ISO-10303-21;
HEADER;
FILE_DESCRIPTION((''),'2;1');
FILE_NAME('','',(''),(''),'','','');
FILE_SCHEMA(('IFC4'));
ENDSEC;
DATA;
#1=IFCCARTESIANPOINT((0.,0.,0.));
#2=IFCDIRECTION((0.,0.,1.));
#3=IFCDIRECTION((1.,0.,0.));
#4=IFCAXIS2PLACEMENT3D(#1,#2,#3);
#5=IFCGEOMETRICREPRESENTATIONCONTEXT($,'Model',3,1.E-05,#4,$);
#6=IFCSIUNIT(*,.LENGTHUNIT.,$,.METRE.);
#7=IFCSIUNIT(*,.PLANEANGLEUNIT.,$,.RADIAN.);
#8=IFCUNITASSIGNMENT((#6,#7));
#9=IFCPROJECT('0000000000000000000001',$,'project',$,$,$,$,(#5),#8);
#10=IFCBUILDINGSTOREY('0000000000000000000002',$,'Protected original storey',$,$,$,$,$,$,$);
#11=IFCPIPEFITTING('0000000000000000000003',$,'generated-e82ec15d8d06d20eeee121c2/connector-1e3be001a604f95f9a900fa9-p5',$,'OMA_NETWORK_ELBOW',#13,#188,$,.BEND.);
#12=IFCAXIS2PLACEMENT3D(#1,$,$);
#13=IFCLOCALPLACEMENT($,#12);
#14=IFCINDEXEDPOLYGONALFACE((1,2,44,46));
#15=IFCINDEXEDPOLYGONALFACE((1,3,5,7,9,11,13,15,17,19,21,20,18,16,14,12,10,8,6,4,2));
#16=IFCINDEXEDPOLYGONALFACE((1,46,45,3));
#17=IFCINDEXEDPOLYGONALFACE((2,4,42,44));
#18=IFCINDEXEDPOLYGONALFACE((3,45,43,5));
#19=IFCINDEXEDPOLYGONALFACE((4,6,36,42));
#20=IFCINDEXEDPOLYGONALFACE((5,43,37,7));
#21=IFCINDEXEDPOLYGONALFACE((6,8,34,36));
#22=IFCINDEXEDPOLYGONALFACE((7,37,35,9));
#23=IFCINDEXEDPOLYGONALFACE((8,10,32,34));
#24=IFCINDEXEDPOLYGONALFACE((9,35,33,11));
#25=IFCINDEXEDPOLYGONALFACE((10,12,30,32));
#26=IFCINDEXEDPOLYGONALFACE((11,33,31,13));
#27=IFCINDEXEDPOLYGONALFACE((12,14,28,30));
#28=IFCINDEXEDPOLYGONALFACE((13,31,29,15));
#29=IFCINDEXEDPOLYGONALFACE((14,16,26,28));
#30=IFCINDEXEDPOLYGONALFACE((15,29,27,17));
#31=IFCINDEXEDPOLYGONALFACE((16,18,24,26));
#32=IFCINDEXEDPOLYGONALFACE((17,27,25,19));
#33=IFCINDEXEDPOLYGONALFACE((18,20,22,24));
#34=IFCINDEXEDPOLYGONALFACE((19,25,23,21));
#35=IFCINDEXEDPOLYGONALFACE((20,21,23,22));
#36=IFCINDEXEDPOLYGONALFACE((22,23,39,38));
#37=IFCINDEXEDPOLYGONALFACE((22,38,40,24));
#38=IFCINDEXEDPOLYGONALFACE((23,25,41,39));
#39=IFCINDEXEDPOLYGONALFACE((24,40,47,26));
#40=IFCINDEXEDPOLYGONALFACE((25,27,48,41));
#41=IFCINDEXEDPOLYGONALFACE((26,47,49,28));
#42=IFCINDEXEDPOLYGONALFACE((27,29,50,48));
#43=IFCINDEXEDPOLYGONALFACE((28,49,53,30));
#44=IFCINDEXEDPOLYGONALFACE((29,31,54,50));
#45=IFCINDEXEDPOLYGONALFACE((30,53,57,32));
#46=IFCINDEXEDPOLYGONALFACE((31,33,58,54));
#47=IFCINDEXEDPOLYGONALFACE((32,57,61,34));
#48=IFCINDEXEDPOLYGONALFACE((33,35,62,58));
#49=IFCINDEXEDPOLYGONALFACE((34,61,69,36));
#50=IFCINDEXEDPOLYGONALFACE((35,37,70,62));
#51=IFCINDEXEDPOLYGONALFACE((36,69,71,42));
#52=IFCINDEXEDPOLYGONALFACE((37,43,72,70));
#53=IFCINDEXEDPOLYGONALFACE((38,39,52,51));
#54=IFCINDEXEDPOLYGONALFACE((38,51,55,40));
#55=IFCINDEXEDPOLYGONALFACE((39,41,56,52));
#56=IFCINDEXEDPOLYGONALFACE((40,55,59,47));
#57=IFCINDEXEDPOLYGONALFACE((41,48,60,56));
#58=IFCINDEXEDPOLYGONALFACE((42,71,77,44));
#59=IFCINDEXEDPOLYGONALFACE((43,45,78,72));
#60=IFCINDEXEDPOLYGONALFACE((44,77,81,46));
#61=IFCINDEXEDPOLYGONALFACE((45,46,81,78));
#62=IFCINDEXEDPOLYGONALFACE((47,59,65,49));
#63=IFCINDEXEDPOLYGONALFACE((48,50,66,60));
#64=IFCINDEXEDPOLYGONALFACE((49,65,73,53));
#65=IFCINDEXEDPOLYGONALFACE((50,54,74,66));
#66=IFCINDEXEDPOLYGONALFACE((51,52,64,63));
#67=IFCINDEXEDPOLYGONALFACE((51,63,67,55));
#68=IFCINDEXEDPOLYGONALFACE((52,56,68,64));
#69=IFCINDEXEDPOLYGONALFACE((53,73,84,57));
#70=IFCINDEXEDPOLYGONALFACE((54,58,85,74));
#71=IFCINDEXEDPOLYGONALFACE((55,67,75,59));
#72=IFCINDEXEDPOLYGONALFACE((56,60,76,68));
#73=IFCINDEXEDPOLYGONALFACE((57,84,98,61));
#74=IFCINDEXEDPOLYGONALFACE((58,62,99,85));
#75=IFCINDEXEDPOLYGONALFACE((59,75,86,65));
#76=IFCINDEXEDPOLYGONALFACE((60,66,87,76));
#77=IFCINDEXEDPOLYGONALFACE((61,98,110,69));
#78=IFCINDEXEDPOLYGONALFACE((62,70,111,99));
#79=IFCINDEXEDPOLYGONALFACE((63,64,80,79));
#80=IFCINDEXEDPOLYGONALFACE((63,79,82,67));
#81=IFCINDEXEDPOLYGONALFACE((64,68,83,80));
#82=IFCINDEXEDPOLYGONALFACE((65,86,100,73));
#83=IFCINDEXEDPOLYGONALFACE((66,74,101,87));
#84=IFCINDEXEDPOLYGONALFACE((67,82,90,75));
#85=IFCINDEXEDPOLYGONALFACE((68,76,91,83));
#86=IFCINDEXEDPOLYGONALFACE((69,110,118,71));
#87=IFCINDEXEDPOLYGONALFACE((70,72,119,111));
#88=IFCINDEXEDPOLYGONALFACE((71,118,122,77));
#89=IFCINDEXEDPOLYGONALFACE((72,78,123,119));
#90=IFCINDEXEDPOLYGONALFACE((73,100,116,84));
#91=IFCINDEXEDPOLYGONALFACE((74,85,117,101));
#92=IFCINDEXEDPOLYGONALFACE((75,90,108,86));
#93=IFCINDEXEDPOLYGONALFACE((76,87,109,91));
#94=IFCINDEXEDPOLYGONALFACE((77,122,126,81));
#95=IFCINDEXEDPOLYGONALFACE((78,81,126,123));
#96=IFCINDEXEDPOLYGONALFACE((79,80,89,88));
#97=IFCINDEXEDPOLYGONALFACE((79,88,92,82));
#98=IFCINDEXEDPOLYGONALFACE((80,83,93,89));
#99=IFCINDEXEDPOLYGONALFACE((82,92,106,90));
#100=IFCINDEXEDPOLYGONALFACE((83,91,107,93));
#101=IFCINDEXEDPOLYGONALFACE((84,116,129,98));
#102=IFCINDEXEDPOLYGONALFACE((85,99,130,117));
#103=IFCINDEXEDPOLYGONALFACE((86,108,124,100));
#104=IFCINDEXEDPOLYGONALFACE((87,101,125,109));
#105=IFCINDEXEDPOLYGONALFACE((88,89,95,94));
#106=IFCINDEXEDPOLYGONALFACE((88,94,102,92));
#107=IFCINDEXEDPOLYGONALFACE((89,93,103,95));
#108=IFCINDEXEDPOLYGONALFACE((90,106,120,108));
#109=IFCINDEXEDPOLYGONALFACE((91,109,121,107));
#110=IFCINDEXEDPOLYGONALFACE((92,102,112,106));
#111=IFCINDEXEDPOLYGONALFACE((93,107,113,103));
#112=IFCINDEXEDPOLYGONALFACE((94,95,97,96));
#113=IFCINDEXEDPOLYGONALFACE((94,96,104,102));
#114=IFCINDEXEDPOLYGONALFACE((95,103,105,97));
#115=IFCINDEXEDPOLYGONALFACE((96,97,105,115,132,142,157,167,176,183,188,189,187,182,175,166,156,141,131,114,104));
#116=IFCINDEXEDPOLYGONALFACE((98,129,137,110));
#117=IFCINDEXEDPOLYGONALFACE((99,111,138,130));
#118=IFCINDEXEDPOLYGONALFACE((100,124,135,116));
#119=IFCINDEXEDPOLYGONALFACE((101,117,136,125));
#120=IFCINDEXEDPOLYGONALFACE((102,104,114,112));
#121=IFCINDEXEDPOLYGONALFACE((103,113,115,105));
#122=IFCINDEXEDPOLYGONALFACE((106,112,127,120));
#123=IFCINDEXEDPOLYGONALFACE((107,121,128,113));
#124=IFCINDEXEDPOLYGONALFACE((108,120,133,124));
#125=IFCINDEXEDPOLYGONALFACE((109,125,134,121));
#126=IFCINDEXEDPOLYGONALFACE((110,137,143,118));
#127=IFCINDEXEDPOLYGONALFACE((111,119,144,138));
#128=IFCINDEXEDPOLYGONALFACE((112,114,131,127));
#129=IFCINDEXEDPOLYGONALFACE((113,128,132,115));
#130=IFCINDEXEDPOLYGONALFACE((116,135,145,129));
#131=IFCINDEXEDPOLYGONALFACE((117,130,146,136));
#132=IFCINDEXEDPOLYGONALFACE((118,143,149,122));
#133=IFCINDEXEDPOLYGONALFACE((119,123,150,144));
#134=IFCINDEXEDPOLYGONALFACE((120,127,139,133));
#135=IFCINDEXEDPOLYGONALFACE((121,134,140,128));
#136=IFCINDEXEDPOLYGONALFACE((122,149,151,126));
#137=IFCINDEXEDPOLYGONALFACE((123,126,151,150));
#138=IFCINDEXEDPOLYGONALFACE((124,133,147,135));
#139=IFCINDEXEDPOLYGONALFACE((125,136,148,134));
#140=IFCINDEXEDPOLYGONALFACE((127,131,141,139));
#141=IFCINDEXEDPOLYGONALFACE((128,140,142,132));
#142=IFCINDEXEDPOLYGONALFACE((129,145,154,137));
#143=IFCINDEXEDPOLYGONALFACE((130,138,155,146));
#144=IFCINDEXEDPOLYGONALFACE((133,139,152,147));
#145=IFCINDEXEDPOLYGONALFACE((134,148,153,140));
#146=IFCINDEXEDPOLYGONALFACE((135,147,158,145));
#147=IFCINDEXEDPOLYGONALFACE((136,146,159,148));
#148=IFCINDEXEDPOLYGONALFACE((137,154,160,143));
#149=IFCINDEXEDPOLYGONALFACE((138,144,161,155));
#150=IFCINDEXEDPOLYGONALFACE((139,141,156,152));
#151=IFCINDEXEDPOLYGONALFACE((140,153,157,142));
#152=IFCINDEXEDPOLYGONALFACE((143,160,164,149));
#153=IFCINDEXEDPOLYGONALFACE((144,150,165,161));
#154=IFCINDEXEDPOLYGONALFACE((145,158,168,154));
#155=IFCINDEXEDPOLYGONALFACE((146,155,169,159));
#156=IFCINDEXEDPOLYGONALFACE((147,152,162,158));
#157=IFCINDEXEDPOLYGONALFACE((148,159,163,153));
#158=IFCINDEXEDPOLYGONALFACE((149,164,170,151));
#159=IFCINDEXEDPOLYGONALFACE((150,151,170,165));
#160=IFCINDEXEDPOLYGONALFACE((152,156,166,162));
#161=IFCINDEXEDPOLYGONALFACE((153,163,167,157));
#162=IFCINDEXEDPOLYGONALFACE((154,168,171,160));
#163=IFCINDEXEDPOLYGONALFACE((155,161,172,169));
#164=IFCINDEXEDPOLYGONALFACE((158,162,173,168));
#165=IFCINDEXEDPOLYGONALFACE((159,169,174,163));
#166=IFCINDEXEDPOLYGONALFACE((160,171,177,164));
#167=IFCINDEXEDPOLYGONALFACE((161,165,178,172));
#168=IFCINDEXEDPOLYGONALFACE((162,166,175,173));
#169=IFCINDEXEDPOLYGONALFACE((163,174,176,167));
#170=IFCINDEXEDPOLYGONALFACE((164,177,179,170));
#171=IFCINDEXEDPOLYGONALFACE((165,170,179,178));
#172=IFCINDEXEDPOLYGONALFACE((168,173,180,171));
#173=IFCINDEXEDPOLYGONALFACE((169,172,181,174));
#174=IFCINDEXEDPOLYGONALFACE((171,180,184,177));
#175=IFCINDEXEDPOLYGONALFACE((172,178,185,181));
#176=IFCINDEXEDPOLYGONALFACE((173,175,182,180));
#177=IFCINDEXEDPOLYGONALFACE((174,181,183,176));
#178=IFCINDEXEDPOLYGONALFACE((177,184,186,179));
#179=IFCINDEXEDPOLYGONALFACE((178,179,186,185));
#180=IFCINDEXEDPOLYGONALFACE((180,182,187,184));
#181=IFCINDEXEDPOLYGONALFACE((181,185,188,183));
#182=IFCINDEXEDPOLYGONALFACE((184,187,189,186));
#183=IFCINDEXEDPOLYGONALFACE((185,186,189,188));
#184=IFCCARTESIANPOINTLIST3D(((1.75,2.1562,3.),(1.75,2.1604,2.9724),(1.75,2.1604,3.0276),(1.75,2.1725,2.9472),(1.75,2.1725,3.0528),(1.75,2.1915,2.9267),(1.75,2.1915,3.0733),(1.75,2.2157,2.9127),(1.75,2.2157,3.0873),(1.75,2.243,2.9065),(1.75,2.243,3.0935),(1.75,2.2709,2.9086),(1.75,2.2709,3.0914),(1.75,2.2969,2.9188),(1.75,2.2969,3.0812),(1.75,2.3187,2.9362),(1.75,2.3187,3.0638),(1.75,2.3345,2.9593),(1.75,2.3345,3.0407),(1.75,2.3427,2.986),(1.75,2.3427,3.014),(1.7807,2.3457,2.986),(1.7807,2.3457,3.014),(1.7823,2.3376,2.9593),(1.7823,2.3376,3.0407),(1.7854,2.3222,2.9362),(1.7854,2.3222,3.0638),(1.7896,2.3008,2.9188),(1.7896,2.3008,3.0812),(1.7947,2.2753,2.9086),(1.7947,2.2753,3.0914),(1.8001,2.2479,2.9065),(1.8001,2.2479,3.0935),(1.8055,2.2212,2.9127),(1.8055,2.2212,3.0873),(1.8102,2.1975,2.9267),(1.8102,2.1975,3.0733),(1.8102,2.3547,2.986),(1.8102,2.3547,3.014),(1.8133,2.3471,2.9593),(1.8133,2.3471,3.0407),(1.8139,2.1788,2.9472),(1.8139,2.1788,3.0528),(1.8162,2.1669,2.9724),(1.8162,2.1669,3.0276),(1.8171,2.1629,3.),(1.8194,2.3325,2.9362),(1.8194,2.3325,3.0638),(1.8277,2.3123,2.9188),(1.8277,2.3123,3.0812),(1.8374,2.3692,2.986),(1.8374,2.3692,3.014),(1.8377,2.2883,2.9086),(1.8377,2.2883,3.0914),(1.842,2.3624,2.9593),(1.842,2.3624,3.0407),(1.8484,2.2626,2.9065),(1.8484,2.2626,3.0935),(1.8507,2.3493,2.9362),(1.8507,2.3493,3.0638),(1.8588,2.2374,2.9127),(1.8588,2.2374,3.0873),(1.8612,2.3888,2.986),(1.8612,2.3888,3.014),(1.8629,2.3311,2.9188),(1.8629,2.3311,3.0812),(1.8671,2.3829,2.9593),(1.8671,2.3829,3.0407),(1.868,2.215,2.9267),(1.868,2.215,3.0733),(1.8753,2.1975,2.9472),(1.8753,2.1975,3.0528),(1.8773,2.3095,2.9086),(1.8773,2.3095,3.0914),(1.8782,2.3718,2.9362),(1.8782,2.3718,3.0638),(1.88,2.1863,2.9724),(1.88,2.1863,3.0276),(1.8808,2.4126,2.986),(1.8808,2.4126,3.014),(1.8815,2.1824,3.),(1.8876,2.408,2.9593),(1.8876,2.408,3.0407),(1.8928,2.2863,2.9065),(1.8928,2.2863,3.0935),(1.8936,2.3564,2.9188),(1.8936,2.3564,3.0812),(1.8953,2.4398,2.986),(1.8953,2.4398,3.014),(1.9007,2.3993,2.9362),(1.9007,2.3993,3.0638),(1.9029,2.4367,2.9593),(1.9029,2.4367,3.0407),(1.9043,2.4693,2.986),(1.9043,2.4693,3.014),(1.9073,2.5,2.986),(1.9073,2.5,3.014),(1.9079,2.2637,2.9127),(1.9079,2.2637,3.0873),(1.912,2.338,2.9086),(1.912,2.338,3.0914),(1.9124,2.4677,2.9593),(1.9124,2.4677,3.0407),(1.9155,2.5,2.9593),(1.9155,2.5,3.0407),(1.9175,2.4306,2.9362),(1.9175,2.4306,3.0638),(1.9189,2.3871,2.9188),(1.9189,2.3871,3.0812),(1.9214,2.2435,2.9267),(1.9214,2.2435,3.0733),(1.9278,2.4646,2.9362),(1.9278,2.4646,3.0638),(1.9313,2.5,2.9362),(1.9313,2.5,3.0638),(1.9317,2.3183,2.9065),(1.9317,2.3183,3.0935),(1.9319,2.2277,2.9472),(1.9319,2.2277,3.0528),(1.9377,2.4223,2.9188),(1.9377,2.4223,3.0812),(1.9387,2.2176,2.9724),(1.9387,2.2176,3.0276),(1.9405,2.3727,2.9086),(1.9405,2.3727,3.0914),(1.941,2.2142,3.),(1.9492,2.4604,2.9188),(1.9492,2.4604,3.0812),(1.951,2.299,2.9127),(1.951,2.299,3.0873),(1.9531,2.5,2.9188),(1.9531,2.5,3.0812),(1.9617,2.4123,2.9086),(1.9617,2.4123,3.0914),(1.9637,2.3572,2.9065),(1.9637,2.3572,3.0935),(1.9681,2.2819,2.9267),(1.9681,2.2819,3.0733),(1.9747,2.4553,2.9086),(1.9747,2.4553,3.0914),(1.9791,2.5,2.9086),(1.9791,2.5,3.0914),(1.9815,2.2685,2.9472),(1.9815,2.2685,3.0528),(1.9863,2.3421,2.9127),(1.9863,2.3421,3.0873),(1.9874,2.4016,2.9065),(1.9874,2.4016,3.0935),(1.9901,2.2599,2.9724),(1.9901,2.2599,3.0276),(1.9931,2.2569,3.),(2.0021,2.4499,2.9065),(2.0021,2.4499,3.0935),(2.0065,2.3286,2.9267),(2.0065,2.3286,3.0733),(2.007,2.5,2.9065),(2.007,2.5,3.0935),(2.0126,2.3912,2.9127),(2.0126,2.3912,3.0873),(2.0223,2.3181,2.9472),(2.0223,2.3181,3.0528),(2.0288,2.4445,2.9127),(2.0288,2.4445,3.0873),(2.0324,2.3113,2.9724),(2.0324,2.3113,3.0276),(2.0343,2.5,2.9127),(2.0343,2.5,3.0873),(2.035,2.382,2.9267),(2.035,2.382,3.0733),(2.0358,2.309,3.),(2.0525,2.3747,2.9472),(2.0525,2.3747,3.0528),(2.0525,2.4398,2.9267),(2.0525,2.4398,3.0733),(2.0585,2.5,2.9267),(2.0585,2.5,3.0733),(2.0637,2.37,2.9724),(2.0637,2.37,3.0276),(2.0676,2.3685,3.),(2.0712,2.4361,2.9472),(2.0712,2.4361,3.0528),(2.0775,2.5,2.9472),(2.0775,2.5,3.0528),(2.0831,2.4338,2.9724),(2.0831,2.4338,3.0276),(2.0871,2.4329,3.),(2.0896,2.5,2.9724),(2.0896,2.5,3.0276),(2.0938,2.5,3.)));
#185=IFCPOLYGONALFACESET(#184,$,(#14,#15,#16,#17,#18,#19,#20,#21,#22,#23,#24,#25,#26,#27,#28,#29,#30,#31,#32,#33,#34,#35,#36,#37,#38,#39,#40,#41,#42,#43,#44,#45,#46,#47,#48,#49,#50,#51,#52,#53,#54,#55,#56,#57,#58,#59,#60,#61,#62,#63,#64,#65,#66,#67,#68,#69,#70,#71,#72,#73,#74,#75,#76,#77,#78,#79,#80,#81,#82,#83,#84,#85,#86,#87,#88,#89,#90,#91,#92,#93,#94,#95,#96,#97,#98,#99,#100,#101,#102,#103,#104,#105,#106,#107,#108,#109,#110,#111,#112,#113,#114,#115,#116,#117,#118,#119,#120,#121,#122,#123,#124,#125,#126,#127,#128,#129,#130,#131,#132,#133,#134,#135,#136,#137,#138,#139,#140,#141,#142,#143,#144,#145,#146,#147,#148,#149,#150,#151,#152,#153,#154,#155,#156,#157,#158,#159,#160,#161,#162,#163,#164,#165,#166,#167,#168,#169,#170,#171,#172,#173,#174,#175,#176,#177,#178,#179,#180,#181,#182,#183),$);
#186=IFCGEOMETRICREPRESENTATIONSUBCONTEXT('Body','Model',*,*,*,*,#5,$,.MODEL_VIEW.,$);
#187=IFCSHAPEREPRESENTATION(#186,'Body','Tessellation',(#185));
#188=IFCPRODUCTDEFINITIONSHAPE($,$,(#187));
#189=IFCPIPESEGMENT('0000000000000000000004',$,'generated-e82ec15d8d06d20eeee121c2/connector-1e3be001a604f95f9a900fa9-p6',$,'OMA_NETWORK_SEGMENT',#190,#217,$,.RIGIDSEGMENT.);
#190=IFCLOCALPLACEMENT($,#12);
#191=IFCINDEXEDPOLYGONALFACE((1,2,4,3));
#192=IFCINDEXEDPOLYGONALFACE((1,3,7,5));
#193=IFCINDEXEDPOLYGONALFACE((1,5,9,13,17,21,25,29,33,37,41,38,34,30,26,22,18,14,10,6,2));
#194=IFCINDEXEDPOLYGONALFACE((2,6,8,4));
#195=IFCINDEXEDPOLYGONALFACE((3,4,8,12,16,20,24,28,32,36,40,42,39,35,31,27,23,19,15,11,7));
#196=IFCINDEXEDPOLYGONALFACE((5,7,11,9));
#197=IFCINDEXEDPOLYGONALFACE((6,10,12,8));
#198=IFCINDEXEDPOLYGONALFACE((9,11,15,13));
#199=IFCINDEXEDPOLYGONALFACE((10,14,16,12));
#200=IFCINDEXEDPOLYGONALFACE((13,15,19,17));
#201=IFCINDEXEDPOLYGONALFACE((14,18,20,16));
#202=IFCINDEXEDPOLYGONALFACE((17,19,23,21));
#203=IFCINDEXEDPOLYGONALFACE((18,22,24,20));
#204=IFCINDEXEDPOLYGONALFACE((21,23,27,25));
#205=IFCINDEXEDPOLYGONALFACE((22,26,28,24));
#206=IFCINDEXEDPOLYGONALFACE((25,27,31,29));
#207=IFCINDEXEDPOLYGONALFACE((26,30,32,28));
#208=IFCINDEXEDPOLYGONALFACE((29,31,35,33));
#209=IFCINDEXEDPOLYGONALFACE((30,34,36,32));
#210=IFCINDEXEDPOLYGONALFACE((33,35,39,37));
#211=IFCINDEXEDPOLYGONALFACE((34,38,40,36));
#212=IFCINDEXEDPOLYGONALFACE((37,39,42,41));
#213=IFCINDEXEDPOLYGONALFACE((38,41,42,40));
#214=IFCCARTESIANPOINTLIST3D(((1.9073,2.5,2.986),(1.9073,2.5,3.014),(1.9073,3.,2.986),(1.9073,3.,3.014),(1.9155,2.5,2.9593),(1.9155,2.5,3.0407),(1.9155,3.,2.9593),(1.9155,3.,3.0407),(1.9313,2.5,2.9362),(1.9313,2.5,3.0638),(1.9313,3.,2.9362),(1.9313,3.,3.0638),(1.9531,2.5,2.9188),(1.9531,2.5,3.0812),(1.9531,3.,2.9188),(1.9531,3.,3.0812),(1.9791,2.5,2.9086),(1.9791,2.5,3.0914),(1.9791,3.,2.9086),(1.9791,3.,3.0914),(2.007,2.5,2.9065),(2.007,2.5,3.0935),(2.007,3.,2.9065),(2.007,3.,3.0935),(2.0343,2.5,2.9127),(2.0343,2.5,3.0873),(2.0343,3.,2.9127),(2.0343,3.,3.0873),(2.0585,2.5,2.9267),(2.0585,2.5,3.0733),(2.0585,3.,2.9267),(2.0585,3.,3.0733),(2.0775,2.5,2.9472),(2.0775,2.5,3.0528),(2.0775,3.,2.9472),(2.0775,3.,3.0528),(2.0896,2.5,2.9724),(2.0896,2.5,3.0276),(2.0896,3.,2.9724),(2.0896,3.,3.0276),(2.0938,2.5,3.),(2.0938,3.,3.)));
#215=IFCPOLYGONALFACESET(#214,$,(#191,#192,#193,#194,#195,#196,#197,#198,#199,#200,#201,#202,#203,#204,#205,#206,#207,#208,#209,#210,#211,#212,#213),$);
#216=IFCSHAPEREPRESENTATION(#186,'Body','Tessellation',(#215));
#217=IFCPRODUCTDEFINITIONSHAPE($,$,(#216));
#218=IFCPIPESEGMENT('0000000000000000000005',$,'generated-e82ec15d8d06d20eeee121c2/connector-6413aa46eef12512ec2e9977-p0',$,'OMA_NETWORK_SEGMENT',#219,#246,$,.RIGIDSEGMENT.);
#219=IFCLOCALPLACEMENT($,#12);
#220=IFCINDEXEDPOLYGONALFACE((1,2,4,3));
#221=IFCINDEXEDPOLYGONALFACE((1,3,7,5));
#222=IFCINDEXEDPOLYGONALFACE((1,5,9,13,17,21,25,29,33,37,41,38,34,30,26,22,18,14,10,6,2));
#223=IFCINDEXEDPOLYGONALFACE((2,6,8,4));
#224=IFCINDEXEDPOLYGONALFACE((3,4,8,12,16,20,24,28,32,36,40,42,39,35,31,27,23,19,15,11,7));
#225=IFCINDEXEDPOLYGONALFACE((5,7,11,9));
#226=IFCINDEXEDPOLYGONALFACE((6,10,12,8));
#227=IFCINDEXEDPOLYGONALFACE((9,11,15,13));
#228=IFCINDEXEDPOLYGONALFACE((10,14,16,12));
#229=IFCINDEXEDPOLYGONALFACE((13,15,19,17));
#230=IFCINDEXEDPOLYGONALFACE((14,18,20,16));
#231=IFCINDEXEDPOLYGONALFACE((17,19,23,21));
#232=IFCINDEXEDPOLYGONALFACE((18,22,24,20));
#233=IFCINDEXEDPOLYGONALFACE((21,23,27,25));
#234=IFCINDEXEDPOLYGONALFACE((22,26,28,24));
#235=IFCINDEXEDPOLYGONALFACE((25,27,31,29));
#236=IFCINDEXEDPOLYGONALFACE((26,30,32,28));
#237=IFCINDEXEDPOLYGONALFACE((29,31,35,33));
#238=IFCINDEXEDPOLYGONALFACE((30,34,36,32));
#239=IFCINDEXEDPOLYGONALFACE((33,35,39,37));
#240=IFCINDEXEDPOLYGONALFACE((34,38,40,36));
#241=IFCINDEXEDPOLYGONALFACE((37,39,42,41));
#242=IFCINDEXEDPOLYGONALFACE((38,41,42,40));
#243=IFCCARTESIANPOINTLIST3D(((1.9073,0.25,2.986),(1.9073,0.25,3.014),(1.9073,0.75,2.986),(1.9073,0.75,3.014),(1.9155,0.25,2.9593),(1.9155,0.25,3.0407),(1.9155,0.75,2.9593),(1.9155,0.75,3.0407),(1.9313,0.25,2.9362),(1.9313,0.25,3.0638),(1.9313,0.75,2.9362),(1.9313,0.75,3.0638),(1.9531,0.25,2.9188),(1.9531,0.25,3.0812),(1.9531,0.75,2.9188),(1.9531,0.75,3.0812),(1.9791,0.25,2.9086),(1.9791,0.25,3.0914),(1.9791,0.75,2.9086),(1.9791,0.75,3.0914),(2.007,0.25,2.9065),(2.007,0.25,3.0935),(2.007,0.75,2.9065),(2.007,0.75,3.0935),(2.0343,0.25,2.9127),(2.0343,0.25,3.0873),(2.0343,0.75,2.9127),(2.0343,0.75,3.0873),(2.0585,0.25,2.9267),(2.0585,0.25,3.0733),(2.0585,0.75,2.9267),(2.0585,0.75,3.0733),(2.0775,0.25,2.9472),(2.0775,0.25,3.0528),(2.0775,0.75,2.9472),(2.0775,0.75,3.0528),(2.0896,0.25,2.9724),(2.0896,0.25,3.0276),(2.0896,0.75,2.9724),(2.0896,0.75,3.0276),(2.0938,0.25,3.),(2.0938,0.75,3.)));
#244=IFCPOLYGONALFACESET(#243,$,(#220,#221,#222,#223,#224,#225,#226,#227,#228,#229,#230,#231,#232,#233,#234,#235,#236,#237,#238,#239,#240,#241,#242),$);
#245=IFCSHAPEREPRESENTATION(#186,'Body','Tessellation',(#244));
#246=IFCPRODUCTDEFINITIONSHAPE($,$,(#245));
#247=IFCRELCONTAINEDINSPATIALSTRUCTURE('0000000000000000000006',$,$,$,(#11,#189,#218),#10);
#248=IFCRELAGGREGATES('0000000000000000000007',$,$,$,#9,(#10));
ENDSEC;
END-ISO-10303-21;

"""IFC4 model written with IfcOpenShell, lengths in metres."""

from ifc_helpers import new_model, entity, si_unit, frame, origin_with_axes, origin_2d, place, context, subcontext, project, spatial, circle, extrude, element, save


model = new_model("IFC4")

# Units and contexts
model_context = context("Model", 3, precision=1e-05, world=origin_with_axes())
body_context = subcontext(model_context, "Body", "Model", "MODEL_VIEW")
ifc_project = project(units=[si_unit("LENGTHUNIT", "METRE"), si_unit("PLANEANGLEUNIT", "RADIAN")], contexts=[model_context])

# Storey
storey = spatial("IfcBuildingStorey", under=ifc_project, Name="Protected original storey")

# Pipe fitting
pipe_fitting_1_placement = place(None, origin_with_axes())
element("IfcPipeFitting", 1, at=pipe_fitting_1_placement, inside=storey, Name="generated-e82ec15d8d06d20eeee121c2/connector-1e3be001a604f95f9a900fa9-p5", ObjectType="OMA_NETWORK_ELBOW", PredefinedType="BEND", context=body_context, shape_type="SweptSolid", body=[
    entity("IfcRevolvedAreaSolid", entity("IfcCircleProfileDef", "AREA", None, entity("IfcAxis2Placement2D", entity("IfcCartesianPoint", [0.25, 0.0])), 0.0938), entity("IfcAxis2Placement3D", entity("IfcCartesianPoint", [1.75, 2.5, 3.0]), entity("IfcDirection", [1.0, 0.0, 0.0]), entity("IfcDirection", [0.0, -1.0, 0.0])), entity("IfcAxis1Placement", entity("IfcCartesianPoint", [0.0, 0.0, 0.0]), entity("IfcDirection", [0.0, -1.0, 0.0])), 1.570796),
])

# Pipe segments
pipe_segment_1_placement = place(None, origin_with_axes())
element("IfcPipeSegment", 2, at=pipe_segment_1_placement, inside=storey, Name="generated-e82ec15d8d06d20eeee121c2/connector-1e3be001a604f95f9a900fa9-p6", ObjectType="OMA_NETWORK_SEGMENT", PredefinedType="RIGIDSEGMENT", context=body_context, shape_type="SweptSolid", body=[
    extrude(circle(Radius=0.0938, at=origin_2d()), frame((2.0, 2.5, 3.0), z_axis=(0.0, 1.0, 0.0), x_axis=(1.0, 0.0, 0.0)), (0.0, 0.0, 1.0), 0.5),
])
pipe_segment_2_placement = place(None, origin_with_axes())
element("IfcPipeSegment", 3, at=pipe_segment_2_placement, inside=storey, Name="generated-e82ec15d8d06d20eeee121c2/connector-6413aa46eef12512ec2e9977-p0", ObjectType="OMA_NETWORK_SEGMENT", PredefinedType="RIGIDSEGMENT", context=body_context, shape_type="SweptSolid", body=[
    extrude(circle(Radius=0.0938, at=origin_2d()), frame((2.0, 0.25, 3.0), z_axis=(0.0, 1.0, 0.0), x_axis=(1.0, 0.0, 0.0)), (0.0, 0.0, 1.0), 0.5),
])

save(model, "model.ifc")
